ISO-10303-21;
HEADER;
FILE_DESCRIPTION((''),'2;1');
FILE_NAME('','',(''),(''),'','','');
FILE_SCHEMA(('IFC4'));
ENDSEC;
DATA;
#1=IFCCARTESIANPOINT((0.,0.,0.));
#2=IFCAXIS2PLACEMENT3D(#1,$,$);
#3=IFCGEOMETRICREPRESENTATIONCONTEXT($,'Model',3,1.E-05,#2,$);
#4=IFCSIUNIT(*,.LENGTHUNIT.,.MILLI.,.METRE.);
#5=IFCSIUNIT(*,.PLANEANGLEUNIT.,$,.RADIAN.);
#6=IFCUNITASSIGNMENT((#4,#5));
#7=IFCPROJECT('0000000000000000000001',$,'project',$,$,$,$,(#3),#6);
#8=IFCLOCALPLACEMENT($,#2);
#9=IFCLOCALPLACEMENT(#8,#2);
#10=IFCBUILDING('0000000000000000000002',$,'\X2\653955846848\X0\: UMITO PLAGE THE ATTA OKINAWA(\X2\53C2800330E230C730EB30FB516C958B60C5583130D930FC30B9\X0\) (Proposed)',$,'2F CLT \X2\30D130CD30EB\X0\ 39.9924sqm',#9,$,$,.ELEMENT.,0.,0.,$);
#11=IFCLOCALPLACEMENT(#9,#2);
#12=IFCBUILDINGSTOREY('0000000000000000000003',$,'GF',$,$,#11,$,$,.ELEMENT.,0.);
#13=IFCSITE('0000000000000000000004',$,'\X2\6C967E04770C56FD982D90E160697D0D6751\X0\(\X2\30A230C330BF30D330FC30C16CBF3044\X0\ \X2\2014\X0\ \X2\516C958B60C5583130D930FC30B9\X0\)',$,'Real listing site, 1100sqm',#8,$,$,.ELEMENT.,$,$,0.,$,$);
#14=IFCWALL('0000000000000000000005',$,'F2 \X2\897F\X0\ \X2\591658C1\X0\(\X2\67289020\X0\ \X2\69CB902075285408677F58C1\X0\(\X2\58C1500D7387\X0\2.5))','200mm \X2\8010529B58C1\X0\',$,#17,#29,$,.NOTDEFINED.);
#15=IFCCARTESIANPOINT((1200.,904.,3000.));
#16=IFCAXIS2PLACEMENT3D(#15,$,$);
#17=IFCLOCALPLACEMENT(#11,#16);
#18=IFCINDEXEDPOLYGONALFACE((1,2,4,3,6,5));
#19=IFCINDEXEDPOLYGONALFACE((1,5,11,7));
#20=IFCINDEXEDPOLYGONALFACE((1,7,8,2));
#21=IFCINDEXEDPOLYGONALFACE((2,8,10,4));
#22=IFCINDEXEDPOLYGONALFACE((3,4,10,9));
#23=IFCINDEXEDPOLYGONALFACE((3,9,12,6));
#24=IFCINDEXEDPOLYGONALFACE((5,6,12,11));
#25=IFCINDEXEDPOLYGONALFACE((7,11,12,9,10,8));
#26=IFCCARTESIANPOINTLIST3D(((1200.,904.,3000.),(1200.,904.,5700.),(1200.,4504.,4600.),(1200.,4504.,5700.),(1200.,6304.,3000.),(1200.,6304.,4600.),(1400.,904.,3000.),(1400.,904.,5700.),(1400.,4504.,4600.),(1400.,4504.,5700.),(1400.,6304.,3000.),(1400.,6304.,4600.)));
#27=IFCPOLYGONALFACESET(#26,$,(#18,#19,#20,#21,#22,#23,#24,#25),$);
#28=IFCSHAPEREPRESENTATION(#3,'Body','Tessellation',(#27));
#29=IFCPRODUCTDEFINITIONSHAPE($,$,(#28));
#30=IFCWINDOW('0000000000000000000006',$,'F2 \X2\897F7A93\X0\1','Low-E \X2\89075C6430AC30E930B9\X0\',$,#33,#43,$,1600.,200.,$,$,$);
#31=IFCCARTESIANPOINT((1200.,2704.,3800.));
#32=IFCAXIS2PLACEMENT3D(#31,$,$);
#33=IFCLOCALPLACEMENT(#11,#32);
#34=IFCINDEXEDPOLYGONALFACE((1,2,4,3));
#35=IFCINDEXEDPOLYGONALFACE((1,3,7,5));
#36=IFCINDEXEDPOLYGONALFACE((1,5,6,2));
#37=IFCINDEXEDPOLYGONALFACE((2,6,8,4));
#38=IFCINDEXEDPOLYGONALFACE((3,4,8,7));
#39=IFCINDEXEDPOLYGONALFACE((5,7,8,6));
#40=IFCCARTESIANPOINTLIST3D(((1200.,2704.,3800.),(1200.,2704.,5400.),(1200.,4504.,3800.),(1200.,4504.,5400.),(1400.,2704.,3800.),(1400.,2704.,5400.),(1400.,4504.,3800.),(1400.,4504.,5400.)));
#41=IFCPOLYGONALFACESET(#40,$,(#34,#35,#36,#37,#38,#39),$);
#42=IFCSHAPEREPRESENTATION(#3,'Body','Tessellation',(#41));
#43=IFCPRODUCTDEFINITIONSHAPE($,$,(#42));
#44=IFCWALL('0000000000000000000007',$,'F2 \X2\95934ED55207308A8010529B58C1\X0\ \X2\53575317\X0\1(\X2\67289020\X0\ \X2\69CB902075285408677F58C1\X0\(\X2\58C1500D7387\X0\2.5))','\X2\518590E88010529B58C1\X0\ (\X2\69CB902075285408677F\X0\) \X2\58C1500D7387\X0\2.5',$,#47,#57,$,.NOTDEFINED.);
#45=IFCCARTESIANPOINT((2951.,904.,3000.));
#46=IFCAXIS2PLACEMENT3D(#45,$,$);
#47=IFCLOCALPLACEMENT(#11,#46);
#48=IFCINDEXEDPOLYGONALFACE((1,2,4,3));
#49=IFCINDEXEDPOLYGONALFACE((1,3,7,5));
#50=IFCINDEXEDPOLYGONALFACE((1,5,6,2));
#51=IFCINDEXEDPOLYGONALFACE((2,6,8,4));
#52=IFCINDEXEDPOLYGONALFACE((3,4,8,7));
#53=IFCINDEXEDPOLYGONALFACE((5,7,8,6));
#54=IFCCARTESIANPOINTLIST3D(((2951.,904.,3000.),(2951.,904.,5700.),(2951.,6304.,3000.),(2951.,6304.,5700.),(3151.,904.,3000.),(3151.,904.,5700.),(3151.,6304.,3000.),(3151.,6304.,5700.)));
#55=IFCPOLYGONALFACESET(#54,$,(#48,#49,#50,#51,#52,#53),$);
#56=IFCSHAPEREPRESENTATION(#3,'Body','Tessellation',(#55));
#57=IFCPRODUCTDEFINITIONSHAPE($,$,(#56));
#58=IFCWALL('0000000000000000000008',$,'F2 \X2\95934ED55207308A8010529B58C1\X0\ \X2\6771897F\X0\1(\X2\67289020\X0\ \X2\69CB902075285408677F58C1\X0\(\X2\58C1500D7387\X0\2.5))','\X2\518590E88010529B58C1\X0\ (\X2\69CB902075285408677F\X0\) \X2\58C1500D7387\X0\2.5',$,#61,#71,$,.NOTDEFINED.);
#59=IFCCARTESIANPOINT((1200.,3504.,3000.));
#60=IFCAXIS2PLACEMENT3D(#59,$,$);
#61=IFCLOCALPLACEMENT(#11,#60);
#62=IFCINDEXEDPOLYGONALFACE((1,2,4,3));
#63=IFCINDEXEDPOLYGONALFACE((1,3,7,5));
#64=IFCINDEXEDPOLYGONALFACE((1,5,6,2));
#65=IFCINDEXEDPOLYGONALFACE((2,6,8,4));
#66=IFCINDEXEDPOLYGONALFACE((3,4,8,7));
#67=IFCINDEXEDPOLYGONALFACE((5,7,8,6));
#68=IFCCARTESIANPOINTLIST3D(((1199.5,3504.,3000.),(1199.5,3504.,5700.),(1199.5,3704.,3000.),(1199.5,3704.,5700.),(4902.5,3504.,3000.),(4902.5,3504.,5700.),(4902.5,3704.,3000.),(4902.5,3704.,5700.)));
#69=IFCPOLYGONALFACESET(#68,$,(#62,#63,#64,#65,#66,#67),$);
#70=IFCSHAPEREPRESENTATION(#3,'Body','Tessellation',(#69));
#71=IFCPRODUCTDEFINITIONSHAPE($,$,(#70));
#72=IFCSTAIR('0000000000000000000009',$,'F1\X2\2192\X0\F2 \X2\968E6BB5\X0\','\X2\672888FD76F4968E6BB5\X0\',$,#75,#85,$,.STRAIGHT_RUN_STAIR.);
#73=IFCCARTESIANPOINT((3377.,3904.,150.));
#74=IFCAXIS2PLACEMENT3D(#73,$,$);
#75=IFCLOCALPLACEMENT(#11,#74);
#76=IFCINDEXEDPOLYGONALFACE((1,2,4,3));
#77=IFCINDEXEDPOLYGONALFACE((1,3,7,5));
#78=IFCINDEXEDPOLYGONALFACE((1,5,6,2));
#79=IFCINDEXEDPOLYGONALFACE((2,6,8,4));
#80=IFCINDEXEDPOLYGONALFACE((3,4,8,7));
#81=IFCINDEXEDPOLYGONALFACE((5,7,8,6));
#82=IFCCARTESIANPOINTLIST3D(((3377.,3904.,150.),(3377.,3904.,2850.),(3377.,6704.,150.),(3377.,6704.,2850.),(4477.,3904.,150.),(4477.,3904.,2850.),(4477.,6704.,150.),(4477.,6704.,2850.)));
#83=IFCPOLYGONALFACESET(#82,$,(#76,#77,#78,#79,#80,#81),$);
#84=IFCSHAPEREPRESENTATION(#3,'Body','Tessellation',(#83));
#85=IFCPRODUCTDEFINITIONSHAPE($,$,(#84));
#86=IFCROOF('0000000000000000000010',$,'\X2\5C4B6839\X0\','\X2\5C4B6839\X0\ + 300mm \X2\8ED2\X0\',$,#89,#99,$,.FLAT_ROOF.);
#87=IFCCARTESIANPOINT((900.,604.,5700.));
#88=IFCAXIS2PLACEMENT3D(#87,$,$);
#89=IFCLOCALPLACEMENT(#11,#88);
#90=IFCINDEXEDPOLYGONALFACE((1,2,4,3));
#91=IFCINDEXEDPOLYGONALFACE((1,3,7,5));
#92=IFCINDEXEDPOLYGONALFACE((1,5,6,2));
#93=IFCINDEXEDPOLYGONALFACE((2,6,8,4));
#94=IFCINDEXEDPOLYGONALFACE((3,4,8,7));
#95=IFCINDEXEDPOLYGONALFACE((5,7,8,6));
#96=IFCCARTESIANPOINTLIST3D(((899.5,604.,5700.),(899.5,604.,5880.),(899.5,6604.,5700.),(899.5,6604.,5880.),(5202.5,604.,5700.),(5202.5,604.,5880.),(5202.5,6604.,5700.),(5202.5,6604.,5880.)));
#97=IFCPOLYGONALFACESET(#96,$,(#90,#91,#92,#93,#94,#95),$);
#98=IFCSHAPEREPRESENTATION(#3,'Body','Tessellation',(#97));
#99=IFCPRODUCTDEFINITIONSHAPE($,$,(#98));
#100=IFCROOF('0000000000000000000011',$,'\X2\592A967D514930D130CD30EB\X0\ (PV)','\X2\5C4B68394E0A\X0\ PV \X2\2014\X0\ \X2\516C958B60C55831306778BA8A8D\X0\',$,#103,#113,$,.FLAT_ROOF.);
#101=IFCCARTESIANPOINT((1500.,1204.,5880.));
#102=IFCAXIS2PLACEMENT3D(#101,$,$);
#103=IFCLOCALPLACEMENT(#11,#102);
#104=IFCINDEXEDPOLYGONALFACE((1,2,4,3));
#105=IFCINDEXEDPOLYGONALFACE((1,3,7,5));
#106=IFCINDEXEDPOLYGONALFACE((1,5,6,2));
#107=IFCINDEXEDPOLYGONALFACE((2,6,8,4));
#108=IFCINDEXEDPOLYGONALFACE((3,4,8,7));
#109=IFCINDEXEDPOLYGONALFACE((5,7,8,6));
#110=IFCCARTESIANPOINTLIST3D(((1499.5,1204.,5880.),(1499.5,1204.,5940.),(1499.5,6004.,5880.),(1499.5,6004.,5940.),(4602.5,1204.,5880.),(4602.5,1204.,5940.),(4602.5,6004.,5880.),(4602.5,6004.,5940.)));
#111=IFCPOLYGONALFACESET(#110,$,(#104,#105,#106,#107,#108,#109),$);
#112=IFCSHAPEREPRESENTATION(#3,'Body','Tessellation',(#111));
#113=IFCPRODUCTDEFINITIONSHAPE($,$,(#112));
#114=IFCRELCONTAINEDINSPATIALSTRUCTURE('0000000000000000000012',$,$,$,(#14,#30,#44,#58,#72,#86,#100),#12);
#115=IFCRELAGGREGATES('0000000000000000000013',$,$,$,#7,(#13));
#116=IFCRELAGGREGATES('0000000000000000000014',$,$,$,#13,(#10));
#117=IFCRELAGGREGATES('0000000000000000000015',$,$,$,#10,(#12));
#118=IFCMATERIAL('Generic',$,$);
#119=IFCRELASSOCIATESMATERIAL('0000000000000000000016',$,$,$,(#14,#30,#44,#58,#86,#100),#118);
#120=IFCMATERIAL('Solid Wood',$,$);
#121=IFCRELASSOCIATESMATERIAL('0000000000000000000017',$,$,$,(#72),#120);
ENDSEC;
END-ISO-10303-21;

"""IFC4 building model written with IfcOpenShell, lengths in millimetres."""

from ifc_helpers import new_model, si_unit, frame, frame_2d, origin, place, context, project, spatial, rectangle, extrude, material, element, fill, save


model = new_model("IFC4")

# Units and contexts
model_context = context("Model", 3, precision=1e-05, world=origin())
ifc_project = project(units=[si_unit("LENGTHUNIT", "METRE", prefix="MILLI"), si_unit("PLANEANGLEUNIT", "RADIAN")], contexts=[model_context])

# Site, building, storey
site_placement = place(None, origin())
site = spatial("IfcSite", under=ifc_project, at=site_placement, Name="沖縄県国頭郡恩納村(アッタビーチ沿い — 公開情報ベース)", ObjectType="Real listing site, 1100sqm", CompositionType="ELEMENT", RefElevation=0.0)
building_placement = place(site_placement, origin())
building = spatial("IfcBuilding", under=site, at=building_placement, Name="改善案: UMITO PLAGE THE ATTA OKINAWA(参考モデル・公開情報ベース) (Proposed)", ObjectType="2F CLT パネル 39.9924sqm", CompositionType="ELEMENT", ElevationOfRefHeight=0.0, ElevationOfTerrain=0.0)
storey_placement = place(building_placement, origin())
storey = spatial("IfcBuildingStorey", under=building, at=storey_placement, Name="GF", CompositionType="ELEMENT", Elevation=0.0)

# Shared definitions
ifc_material_1 = material(Name="Generic")

# Shared definitions
ifc_material_2 = material(Name="Solid Wood")

# Wall, opening, window
wall_1_placement = place(storey_placement, frame((1200.0, 904.0, 3000.0)))
wall_1 = element("IfcWall", 1, at=wall_1_placement, inside=storey, material=ifc_material_1, Name="F2 西 外壁(木造 構造用合板壁(壁倍率2.5))", Description="200mm 耐力壁", PredefinedType="NOTDEFINED", context=model_context, shape_type="SweptSolid", body=[
    extrude(rectangle(XDim=200.0, YDim=5400.0, at=frame_2d((100.0, 2700.0))), frame((1200.0, 904.0, 3000.0)), (0.0, 0.0, 1.0), 2700.0),
])
opening_1_placement = place(storey_placement, frame((1200.0, 2704.0, 3800.0)))
opening_1 = element("IfcOpeningElement", 2, at=opening_1_placement, cuts=wall_1, PredefinedType="NOTDEFINED", context=model_context, shape_type="SweptSolid", body=[
    extrude(rectangle(XDim=200.0, YDim=1800.0, at=frame_2d((100.0, 900.0))), frame((1200.0, 2704.0, 3800.0)), (0.0, 0.0, 1.0), 1600.0),
])
window_1_placement = place(storey_placement, frame((1200.0, 2704.0, 3800.0)))
window_1 = element("IfcWindow", 3, at=window_1_placement, inside=storey, material=ifc_material_1, Name="F2 西窓1", Description="Low-E 複層ガラス", OverallHeight=1600.0, OverallWidth=200.0, context=model_context, shape_type="SweptSolid", body=[
    extrude(rectangle(XDim=200.0, YDim=1800.0, at=frame_2d((100.0, 900.0))), frame((1200.0, 2704.0, 3800.0)), (0.0, 0.0, 1.0), 1600.0),
])
fill(opening_1, window_1)

# Walls
wall_2_placement = place(storey_placement, frame((2951.0, 904.0, 3000.0)))
element("IfcWall", 4, at=wall_2_placement, inside=storey, material=ifc_material_1, Name="F2 間仕切り耐力壁 南北1(木造 構造用合板壁(壁倍率2.5))", Description="内部耐力壁 (構造用合板) 壁倍率2.5", PredefinedType="NOTDEFINED", context=model_context, shape_type="SweptSolid", body=[
    extrude(rectangle(XDim=200.0, YDim=5400.0, at=frame_2d((100.0, 2700.0))), frame((2951.0, 904.0, 3000.0)), (0.0, 0.0, 1.0), 2700.0),
])
wall_3_placement = place(storey_placement, frame((1200.0, 3504.0, 3000.0)))
element("IfcWall", 5, at=wall_3_placement, inside=storey, material=ifc_material_1, Name="F2 間仕切り耐力壁 東西1(木造 構造用合板壁(壁倍率2.5))", Description="内部耐力壁 (構造用合板) 壁倍率2.5", PredefinedType="NOTDEFINED", context=model_context, shape_type="SweptSolid", body=[
    extrude(rectangle(XDim=3703.0, YDim=200.0, at=frame_2d((1851.0, 100.0))), frame((1200.0, 3504.0, 3000.0)), (0.0, 0.0, 1.0), 2700.0),
])

# Stair
stair_placement = place(storey_placement, frame((3377.0, 3904.0, 150.0)))
element("IfcStair", 6, at=stair_placement, inside=storey, material=ifc_material_2, Name="F1→F2 階段", Description="木製直階段", PredefinedType="STRAIGHT_RUN_STAIR", context=model_context, shape_type="SweptSolid", body=[
    extrude(rectangle(XDim=1100.0, YDim=2800.0, at=frame_2d((550.0, 1400.0))), frame((3377.0, 3904.0, 150.0)), (0.0, 0.0, 1.0), 2700.0),
])

# Roofs
roof_1_placement = place(storey_placement, frame((900.0, 604.0, 5700.0)))
element("IfcRoof", 7, at=roof_1_placement, inside=storey, material=ifc_material_1, Name="屋根", Description="屋根 + 300mm 軒", PredefinedType="FLAT_ROOF", context=model_context, shape_type="SweptSolid", body=[
    extrude(rectangle(XDim=4303.0, YDim=6000.0, at=frame_2d((2151.0, 3000.0))), frame((900.0, 604.0, 5700.0)), (0.0, 0.0, 1.0), 180.0),
])
roof_2_placement = place(storey_placement, frame((1500.0, 1204.0, 5880.0)))
element("IfcRoof", 8, at=roof_2_placement, inside=storey, material=ifc_material_1, Name="太陽光パネル (PV)", Description="屋根上 PV — 公開情報で確認", PredefinedType="FLAT_ROOF", context=model_context, shape_type="SweptSolid", body=[
    extrude(rectangle(XDim=3103.0, YDim=4800.0, at=frame_2d((1551.0, 2400.0))), frame((1500.0, 1204.0, 5880.0)), (0.0, 0.0, 1.0), 60.0),
])

save(model, "model.ifc")
